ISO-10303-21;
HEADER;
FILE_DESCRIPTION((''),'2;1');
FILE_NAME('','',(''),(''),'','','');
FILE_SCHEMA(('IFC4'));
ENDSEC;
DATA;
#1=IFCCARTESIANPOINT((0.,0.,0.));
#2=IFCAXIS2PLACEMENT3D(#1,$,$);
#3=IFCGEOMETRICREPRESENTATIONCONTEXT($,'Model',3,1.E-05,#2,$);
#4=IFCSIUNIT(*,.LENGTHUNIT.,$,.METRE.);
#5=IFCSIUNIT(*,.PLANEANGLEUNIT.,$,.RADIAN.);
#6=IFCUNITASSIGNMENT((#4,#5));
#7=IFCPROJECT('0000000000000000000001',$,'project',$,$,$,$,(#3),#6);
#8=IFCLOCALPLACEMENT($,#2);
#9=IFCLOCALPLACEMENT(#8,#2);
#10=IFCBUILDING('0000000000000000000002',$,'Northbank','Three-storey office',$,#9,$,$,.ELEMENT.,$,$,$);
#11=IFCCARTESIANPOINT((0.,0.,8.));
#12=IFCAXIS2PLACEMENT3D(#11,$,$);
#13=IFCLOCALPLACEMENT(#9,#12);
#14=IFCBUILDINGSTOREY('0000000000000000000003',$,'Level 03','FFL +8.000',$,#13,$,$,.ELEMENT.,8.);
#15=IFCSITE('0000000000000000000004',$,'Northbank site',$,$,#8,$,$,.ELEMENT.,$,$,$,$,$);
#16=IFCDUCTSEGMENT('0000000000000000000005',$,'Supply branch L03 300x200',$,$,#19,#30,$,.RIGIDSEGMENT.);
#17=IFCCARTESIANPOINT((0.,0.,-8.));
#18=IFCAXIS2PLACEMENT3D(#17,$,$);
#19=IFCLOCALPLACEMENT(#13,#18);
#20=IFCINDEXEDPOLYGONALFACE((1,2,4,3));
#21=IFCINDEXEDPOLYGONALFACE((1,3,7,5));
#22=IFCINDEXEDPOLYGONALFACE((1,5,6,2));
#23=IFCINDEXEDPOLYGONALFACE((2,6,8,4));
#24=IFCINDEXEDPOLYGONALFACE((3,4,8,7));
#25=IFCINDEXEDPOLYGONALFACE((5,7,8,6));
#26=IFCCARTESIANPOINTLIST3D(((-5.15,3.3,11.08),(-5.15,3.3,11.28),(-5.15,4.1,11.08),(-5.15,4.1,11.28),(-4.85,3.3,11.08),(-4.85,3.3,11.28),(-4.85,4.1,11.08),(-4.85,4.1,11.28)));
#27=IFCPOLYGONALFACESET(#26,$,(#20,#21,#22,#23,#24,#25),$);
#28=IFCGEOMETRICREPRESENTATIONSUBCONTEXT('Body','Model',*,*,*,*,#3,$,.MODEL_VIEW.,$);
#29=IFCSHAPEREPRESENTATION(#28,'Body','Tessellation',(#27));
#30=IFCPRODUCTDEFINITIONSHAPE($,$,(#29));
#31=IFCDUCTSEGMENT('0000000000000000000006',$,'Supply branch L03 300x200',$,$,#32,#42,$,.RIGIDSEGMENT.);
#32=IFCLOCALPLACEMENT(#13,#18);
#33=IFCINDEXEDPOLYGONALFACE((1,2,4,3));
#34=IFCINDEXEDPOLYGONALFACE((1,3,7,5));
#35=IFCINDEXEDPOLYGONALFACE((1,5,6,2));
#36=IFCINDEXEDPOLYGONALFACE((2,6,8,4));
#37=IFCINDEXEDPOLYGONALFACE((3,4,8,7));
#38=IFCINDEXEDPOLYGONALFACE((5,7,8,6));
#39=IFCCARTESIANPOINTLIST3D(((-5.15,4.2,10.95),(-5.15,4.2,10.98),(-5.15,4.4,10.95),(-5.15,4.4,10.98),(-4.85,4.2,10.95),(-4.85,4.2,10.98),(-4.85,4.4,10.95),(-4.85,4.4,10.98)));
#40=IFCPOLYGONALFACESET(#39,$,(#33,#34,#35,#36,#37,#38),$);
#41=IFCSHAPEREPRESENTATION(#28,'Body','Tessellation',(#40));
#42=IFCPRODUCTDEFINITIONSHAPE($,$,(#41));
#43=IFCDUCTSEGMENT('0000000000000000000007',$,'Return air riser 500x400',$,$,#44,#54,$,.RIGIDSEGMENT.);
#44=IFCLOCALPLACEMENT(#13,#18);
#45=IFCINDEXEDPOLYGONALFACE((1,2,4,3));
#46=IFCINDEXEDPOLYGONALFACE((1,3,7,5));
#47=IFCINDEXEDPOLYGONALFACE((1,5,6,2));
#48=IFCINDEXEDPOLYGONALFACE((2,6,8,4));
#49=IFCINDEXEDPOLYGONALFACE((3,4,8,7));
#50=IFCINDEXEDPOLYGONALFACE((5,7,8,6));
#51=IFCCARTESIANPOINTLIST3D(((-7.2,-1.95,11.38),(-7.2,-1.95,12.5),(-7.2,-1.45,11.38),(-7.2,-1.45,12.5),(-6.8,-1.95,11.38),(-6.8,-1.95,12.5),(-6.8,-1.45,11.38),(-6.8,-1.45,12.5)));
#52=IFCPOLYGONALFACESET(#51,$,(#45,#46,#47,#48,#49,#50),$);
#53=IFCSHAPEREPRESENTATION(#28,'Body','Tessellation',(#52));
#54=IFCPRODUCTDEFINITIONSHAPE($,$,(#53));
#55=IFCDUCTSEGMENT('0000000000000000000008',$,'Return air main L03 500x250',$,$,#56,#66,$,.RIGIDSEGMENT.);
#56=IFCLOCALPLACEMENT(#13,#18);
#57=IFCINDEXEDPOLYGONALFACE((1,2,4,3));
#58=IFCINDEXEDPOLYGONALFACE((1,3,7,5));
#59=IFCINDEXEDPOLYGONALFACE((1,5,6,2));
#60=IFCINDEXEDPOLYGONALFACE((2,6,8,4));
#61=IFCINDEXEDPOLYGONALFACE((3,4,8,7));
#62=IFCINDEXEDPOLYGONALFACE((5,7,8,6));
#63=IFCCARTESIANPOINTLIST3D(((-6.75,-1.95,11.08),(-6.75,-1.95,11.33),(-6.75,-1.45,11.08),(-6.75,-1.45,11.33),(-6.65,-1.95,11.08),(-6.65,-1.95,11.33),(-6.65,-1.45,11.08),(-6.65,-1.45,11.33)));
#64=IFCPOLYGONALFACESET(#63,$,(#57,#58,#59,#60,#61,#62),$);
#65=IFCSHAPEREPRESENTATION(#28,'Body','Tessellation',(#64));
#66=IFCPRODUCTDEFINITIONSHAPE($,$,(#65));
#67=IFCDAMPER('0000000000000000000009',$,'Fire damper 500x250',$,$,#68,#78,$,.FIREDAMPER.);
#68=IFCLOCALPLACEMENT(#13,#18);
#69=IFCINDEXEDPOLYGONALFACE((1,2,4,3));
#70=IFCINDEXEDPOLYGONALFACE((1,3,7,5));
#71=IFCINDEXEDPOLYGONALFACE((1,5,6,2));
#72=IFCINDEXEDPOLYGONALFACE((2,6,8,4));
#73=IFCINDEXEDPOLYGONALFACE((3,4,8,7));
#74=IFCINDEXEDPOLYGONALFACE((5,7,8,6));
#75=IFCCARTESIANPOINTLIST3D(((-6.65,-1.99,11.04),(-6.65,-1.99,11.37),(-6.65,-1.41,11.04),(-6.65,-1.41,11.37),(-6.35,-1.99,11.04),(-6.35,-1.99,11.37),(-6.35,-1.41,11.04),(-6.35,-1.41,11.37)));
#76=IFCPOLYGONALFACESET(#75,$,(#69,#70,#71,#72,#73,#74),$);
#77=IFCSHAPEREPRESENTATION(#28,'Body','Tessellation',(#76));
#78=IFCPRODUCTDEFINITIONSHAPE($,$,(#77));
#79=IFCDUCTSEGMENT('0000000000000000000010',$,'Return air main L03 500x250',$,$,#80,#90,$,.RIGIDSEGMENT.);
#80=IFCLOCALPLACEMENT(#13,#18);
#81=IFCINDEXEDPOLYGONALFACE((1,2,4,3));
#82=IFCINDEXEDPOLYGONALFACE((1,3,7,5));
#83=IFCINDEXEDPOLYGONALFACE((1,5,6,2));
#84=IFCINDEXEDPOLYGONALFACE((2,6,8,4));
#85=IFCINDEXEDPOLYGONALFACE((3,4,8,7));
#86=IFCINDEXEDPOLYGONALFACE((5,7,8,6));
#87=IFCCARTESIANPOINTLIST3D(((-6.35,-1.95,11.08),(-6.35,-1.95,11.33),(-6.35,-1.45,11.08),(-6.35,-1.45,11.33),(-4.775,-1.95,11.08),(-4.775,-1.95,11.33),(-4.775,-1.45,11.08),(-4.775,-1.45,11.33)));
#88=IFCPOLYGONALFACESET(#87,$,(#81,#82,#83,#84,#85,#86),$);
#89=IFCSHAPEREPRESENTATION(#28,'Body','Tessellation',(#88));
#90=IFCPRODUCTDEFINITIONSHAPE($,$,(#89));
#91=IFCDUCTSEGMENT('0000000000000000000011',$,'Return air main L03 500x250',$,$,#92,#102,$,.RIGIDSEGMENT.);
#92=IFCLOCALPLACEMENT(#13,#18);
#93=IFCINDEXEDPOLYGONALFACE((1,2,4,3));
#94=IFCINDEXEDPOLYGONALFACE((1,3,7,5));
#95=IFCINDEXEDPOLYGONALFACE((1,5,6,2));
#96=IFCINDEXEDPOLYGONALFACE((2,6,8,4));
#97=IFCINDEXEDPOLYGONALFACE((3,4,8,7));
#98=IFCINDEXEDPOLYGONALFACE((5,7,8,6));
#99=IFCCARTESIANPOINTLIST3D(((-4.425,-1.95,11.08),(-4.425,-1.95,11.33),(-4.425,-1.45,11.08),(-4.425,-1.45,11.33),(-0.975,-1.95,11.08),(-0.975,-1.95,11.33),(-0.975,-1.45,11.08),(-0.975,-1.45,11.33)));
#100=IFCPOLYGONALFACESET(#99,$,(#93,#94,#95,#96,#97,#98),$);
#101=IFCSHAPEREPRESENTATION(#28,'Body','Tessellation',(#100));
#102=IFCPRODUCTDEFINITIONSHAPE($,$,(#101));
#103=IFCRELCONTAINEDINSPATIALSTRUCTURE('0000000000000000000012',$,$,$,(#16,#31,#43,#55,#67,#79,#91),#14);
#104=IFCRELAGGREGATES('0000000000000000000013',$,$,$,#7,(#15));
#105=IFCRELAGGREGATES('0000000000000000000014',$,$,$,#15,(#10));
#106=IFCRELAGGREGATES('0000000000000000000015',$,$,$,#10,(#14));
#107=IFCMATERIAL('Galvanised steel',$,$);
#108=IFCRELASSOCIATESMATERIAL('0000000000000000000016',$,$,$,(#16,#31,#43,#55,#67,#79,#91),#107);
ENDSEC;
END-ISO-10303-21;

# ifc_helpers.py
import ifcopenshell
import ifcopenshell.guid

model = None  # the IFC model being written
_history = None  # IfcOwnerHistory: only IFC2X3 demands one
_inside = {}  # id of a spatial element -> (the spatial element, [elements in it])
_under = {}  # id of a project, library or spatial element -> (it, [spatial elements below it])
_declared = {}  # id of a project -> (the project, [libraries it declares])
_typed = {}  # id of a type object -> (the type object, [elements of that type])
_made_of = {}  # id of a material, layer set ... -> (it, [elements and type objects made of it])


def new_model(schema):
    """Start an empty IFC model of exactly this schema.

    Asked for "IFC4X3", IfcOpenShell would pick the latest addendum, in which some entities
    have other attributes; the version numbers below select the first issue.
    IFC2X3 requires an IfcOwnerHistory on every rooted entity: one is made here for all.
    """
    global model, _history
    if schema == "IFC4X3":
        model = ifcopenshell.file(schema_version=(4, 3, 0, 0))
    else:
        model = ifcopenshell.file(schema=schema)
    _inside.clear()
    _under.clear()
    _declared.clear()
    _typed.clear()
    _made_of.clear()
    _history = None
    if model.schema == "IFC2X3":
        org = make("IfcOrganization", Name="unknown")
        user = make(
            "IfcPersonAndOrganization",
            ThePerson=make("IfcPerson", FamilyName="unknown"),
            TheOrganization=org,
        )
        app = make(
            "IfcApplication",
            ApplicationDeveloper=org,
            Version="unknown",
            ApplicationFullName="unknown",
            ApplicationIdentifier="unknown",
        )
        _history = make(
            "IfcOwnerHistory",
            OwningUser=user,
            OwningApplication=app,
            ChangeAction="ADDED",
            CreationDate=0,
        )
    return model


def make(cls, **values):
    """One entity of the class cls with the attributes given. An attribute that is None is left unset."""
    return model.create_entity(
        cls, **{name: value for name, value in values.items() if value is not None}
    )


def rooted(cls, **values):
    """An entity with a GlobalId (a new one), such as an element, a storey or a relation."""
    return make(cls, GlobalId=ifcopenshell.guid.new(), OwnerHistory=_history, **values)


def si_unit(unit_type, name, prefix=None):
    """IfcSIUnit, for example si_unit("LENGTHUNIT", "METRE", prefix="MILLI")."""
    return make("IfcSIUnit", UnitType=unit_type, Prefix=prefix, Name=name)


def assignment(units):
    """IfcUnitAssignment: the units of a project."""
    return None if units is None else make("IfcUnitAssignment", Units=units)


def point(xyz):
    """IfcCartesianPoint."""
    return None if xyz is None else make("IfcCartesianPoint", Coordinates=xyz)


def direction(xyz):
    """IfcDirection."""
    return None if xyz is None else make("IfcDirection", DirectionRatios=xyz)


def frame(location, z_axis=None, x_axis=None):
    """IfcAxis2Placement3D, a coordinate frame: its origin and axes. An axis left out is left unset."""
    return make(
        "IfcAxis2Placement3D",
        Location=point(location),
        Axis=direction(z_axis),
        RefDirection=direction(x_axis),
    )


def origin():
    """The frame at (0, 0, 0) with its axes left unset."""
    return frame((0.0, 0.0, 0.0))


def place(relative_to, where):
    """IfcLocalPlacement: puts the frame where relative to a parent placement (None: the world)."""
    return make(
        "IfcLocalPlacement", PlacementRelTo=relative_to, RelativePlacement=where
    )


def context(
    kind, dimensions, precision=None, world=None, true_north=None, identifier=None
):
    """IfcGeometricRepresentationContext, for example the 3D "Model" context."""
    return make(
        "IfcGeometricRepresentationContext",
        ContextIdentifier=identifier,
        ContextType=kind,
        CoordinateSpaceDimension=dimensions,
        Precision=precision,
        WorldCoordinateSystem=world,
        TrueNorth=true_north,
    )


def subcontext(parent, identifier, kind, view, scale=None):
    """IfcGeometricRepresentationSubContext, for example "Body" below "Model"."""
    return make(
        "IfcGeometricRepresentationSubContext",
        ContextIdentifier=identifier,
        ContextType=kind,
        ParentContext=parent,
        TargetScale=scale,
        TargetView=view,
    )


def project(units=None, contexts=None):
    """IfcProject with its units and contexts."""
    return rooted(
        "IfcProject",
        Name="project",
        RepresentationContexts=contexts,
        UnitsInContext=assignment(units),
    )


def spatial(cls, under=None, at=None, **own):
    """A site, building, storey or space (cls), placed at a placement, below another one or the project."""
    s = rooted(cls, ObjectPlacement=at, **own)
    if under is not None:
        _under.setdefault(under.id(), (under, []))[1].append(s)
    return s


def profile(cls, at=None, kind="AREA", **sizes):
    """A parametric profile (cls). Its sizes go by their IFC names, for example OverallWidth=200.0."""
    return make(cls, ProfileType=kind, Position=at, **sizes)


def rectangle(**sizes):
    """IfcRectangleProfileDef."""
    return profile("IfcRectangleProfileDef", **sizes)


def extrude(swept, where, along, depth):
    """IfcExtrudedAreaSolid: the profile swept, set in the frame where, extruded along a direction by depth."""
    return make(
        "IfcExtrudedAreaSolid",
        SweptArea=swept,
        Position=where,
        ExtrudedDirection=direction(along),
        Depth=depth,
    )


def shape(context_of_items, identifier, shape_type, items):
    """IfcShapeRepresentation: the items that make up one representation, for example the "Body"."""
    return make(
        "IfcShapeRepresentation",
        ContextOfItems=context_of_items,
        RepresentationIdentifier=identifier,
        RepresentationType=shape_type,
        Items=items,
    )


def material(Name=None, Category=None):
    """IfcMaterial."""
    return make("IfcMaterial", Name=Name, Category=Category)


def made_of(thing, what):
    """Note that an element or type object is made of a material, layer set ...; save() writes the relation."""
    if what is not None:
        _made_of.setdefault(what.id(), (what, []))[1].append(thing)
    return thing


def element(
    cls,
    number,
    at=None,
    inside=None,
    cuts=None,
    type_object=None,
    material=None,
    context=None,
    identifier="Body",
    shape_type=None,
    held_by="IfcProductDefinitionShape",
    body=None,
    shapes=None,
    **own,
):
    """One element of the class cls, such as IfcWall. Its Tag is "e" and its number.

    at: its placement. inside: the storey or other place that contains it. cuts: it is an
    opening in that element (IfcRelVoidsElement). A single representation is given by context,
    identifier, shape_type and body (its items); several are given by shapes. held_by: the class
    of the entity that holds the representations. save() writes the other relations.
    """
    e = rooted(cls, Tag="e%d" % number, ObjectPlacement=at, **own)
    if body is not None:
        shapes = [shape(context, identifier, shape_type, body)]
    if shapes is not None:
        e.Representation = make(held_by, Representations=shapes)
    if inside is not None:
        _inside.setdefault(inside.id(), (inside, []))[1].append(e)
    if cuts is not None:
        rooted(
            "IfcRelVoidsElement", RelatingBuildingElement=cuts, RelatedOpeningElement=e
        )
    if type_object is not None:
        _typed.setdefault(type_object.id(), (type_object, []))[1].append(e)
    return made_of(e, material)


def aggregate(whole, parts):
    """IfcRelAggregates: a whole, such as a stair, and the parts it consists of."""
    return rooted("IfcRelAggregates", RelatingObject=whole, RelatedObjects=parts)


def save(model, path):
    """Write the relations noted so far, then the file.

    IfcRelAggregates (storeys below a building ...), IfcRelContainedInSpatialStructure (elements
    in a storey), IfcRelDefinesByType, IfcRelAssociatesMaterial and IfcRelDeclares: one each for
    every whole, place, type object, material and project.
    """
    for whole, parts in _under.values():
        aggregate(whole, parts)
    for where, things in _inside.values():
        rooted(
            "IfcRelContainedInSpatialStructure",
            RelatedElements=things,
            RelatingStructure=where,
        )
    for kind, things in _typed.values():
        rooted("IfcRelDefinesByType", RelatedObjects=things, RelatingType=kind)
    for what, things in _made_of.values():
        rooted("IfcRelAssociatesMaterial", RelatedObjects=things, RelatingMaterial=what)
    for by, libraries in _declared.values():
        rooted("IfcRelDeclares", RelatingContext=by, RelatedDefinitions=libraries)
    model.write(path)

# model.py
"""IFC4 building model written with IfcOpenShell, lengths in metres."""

from ifc_helpers import new_model, si_unit, frame, origin, place, context, subcontext, project, spatial, rectangle, extrude, material, element, save


model = new_model("IFC4")

# Units and contexts
model_context = context("Model", 3, precision=1e-05, world=origin())
body_context = subcontext(model_context, "Body", "Model", "MODEL_VIEW")
ifc_project = project(units=[si_unit("LENGTHUNIT", "METRE"), si_unit("PLANEANGLEUNIT", "RADIAN")], contexts=[model_context])

# Site, building, storey
site_placement = place(None, origin())
site = spatial("IfcSite", under=ifc_project, at=site_placement, Name="Northbank site", CompositionType="ELEMENT")
building_placement = place(site_placement, origin())
building = spatial("IfcBuilding", under=site, at=building_placement, Name="Northbank", Description="Three-storey office", CompositionType="ELEMENT")
storey_placement = place(building_placement, frame((0.0, 0.0, 8.0)))
storey = spatial("IfcBuildingStorey", under=building, at=storey_placement, Name="Level 03", Description="FFL +8.000", CompositionType="ELEMENT", Elevation=8.0)

# Shared definitions
ifc_material_1 = material(Name="Galvanised steel")

# Duct segments
duct_segment_1_placement = place(storey_placement, frame((0.0, 0.0, -8.0)))
element("IfcDuctSegment", 1, at=duct_segment_1_placement, inside=storey, material=ifc_material_1, Name="Supply branch L03 300x200", PredefinedType="RIGIDSEGMENT", context=body_context, shape_type="SweptSolid", body=[
    extrude(rectangle(XDim=0.3, YDim=0.2), frame((-5.0, 3.3, 11.18), z_axis=(0.0, 1.0, 0.0), x_axis=(-1.0, 0.0, 0.0)), (0.0, 0.0, 1.0), 0.8),
])
duct_segment_2_placement = place(storey_placement, frame((0.0, 0.0, -8.0)))
element("IfcDuctSegment", 2, at=duct_segment_2_placement, inside=storey, material=ifc_material_1, Name="Supply branch L03 300x200", PredefinedType="RIGIDSEGMENT", context=body_context, shape_type="SweptSolid", body=[
    extrude(rectangle(XDim=0.3, YDim=0.2), frame((-5.0, 4.3, 10.98), z_axis=(0.0, 0.0, -1.0), x_axis=(-1.0, 0.0, 0.0)), (0.0, 0.0, 1.0), 0.03),
])

# Duct segments
duct_segment_3_placement = place(storey_placement, frame((0.0, 0.0, -8.0)))
element("IfcDuctSegment", 3, at=duct_segment_3_placement, inside=storey, material=ifc_material_1, Name="Return air riser 500x400", PredefinedType="RIGIDSEGMENT", context=body_context, shape_type="SweptSolid", body=[
    extrude(rectangle(XDim=0.5, YDim=0.4), frame((-7.0, -1.7, 12.5), z_axis=(0.0, 0.0, -1.0), x_axis=(0.0, -1.0, 0.0)), (0.0, 0.0, 1.0), 1.12),
])
duct_segment_4_placement = place(storey_placement, frame((0.0, 0.0, -8.0)))
element("IfcDuctSegment", 4, at=duct_segment_4_placement, inside=storey, material=ifc_material_1, Name="Return air main L03 500x250", PredefinedType="RIGIDSEGMENT", context=body_context, shape_type="SweptSolid", body=[
    extrude(rectangle(XDim=0.5, YDim=0.25), frame((-6.75, -1.7, 11.205), z_axis=(1.0, 0.0, 0.0), x_axis=(0.0, 1.0, 0.0)), (0.0, 0.0, 1.0), 0.1),
])

# Damper
damper_1_placement = place(storey_placement, frame((0.0, 0.0, -8.0)))
element("IfcDamper", 5, at=damper_1_placement, inside=storey, material=ifc_material_1, Name="Fire damper 500x250", PredefinedType="FIREDAMPER", context=body_context, shape_type="SweptSolid", body=[
    extrude(rectangle(XDim=0.58, YDim=0.33), frame((-6.65, -1.7, 11.205), z_axis=(1.0, 0.0, 0.0), x_axis=(0.0, 1.0, 0.0)), (0.0, 0.0, 1.0), 0.3),
])

# Duct segment
duct_segment_5_placement = place(storey_placement, frame((0.0, 0.0, -8.0)))
element("IfcDuctSegment", 6, at=duct_segment_5_placement, inside=storey, material=ifc_material_1, Name="Return air main L03 500x250", PredefinedType="RIGIDSEGMENT", context=body_context, shape_type="SweptSolid", body=[
    extrude(rectangle(XDim=0.5, YDim=0.25), frame((-6.35, -1.7, 11.205), z_axis=(1.0, 0.0, 0.0), x_axis=(0.0, 1.0, 0.0)), (0.0, 0.0, 1.0), 1.575),
])

# Duct segment
duct_segment_6_placement = place(storey_placement, frame((0.0, 0.0, -8.0)))
element("IfcDuctSegment", 7, at=duct_segment_6_placement, inside=storey, material=ifc_material_1, Name="Return air main L03 500x250", PredefinedType="RIGIDSEGMENT", context=body_context, shape_type="SweptSolid", body=[
    extrude(rectangle(XDim=0.5, YDim=0.25), frame((-4.425, -1.7, 11.205), z_axis=(1.0, 0.0, 0.0), x_axis=(0.0, 1.0, 0.0)), (0.0, 0.0, 1.0), 3.45),
])

save(model, "model.ifc")
